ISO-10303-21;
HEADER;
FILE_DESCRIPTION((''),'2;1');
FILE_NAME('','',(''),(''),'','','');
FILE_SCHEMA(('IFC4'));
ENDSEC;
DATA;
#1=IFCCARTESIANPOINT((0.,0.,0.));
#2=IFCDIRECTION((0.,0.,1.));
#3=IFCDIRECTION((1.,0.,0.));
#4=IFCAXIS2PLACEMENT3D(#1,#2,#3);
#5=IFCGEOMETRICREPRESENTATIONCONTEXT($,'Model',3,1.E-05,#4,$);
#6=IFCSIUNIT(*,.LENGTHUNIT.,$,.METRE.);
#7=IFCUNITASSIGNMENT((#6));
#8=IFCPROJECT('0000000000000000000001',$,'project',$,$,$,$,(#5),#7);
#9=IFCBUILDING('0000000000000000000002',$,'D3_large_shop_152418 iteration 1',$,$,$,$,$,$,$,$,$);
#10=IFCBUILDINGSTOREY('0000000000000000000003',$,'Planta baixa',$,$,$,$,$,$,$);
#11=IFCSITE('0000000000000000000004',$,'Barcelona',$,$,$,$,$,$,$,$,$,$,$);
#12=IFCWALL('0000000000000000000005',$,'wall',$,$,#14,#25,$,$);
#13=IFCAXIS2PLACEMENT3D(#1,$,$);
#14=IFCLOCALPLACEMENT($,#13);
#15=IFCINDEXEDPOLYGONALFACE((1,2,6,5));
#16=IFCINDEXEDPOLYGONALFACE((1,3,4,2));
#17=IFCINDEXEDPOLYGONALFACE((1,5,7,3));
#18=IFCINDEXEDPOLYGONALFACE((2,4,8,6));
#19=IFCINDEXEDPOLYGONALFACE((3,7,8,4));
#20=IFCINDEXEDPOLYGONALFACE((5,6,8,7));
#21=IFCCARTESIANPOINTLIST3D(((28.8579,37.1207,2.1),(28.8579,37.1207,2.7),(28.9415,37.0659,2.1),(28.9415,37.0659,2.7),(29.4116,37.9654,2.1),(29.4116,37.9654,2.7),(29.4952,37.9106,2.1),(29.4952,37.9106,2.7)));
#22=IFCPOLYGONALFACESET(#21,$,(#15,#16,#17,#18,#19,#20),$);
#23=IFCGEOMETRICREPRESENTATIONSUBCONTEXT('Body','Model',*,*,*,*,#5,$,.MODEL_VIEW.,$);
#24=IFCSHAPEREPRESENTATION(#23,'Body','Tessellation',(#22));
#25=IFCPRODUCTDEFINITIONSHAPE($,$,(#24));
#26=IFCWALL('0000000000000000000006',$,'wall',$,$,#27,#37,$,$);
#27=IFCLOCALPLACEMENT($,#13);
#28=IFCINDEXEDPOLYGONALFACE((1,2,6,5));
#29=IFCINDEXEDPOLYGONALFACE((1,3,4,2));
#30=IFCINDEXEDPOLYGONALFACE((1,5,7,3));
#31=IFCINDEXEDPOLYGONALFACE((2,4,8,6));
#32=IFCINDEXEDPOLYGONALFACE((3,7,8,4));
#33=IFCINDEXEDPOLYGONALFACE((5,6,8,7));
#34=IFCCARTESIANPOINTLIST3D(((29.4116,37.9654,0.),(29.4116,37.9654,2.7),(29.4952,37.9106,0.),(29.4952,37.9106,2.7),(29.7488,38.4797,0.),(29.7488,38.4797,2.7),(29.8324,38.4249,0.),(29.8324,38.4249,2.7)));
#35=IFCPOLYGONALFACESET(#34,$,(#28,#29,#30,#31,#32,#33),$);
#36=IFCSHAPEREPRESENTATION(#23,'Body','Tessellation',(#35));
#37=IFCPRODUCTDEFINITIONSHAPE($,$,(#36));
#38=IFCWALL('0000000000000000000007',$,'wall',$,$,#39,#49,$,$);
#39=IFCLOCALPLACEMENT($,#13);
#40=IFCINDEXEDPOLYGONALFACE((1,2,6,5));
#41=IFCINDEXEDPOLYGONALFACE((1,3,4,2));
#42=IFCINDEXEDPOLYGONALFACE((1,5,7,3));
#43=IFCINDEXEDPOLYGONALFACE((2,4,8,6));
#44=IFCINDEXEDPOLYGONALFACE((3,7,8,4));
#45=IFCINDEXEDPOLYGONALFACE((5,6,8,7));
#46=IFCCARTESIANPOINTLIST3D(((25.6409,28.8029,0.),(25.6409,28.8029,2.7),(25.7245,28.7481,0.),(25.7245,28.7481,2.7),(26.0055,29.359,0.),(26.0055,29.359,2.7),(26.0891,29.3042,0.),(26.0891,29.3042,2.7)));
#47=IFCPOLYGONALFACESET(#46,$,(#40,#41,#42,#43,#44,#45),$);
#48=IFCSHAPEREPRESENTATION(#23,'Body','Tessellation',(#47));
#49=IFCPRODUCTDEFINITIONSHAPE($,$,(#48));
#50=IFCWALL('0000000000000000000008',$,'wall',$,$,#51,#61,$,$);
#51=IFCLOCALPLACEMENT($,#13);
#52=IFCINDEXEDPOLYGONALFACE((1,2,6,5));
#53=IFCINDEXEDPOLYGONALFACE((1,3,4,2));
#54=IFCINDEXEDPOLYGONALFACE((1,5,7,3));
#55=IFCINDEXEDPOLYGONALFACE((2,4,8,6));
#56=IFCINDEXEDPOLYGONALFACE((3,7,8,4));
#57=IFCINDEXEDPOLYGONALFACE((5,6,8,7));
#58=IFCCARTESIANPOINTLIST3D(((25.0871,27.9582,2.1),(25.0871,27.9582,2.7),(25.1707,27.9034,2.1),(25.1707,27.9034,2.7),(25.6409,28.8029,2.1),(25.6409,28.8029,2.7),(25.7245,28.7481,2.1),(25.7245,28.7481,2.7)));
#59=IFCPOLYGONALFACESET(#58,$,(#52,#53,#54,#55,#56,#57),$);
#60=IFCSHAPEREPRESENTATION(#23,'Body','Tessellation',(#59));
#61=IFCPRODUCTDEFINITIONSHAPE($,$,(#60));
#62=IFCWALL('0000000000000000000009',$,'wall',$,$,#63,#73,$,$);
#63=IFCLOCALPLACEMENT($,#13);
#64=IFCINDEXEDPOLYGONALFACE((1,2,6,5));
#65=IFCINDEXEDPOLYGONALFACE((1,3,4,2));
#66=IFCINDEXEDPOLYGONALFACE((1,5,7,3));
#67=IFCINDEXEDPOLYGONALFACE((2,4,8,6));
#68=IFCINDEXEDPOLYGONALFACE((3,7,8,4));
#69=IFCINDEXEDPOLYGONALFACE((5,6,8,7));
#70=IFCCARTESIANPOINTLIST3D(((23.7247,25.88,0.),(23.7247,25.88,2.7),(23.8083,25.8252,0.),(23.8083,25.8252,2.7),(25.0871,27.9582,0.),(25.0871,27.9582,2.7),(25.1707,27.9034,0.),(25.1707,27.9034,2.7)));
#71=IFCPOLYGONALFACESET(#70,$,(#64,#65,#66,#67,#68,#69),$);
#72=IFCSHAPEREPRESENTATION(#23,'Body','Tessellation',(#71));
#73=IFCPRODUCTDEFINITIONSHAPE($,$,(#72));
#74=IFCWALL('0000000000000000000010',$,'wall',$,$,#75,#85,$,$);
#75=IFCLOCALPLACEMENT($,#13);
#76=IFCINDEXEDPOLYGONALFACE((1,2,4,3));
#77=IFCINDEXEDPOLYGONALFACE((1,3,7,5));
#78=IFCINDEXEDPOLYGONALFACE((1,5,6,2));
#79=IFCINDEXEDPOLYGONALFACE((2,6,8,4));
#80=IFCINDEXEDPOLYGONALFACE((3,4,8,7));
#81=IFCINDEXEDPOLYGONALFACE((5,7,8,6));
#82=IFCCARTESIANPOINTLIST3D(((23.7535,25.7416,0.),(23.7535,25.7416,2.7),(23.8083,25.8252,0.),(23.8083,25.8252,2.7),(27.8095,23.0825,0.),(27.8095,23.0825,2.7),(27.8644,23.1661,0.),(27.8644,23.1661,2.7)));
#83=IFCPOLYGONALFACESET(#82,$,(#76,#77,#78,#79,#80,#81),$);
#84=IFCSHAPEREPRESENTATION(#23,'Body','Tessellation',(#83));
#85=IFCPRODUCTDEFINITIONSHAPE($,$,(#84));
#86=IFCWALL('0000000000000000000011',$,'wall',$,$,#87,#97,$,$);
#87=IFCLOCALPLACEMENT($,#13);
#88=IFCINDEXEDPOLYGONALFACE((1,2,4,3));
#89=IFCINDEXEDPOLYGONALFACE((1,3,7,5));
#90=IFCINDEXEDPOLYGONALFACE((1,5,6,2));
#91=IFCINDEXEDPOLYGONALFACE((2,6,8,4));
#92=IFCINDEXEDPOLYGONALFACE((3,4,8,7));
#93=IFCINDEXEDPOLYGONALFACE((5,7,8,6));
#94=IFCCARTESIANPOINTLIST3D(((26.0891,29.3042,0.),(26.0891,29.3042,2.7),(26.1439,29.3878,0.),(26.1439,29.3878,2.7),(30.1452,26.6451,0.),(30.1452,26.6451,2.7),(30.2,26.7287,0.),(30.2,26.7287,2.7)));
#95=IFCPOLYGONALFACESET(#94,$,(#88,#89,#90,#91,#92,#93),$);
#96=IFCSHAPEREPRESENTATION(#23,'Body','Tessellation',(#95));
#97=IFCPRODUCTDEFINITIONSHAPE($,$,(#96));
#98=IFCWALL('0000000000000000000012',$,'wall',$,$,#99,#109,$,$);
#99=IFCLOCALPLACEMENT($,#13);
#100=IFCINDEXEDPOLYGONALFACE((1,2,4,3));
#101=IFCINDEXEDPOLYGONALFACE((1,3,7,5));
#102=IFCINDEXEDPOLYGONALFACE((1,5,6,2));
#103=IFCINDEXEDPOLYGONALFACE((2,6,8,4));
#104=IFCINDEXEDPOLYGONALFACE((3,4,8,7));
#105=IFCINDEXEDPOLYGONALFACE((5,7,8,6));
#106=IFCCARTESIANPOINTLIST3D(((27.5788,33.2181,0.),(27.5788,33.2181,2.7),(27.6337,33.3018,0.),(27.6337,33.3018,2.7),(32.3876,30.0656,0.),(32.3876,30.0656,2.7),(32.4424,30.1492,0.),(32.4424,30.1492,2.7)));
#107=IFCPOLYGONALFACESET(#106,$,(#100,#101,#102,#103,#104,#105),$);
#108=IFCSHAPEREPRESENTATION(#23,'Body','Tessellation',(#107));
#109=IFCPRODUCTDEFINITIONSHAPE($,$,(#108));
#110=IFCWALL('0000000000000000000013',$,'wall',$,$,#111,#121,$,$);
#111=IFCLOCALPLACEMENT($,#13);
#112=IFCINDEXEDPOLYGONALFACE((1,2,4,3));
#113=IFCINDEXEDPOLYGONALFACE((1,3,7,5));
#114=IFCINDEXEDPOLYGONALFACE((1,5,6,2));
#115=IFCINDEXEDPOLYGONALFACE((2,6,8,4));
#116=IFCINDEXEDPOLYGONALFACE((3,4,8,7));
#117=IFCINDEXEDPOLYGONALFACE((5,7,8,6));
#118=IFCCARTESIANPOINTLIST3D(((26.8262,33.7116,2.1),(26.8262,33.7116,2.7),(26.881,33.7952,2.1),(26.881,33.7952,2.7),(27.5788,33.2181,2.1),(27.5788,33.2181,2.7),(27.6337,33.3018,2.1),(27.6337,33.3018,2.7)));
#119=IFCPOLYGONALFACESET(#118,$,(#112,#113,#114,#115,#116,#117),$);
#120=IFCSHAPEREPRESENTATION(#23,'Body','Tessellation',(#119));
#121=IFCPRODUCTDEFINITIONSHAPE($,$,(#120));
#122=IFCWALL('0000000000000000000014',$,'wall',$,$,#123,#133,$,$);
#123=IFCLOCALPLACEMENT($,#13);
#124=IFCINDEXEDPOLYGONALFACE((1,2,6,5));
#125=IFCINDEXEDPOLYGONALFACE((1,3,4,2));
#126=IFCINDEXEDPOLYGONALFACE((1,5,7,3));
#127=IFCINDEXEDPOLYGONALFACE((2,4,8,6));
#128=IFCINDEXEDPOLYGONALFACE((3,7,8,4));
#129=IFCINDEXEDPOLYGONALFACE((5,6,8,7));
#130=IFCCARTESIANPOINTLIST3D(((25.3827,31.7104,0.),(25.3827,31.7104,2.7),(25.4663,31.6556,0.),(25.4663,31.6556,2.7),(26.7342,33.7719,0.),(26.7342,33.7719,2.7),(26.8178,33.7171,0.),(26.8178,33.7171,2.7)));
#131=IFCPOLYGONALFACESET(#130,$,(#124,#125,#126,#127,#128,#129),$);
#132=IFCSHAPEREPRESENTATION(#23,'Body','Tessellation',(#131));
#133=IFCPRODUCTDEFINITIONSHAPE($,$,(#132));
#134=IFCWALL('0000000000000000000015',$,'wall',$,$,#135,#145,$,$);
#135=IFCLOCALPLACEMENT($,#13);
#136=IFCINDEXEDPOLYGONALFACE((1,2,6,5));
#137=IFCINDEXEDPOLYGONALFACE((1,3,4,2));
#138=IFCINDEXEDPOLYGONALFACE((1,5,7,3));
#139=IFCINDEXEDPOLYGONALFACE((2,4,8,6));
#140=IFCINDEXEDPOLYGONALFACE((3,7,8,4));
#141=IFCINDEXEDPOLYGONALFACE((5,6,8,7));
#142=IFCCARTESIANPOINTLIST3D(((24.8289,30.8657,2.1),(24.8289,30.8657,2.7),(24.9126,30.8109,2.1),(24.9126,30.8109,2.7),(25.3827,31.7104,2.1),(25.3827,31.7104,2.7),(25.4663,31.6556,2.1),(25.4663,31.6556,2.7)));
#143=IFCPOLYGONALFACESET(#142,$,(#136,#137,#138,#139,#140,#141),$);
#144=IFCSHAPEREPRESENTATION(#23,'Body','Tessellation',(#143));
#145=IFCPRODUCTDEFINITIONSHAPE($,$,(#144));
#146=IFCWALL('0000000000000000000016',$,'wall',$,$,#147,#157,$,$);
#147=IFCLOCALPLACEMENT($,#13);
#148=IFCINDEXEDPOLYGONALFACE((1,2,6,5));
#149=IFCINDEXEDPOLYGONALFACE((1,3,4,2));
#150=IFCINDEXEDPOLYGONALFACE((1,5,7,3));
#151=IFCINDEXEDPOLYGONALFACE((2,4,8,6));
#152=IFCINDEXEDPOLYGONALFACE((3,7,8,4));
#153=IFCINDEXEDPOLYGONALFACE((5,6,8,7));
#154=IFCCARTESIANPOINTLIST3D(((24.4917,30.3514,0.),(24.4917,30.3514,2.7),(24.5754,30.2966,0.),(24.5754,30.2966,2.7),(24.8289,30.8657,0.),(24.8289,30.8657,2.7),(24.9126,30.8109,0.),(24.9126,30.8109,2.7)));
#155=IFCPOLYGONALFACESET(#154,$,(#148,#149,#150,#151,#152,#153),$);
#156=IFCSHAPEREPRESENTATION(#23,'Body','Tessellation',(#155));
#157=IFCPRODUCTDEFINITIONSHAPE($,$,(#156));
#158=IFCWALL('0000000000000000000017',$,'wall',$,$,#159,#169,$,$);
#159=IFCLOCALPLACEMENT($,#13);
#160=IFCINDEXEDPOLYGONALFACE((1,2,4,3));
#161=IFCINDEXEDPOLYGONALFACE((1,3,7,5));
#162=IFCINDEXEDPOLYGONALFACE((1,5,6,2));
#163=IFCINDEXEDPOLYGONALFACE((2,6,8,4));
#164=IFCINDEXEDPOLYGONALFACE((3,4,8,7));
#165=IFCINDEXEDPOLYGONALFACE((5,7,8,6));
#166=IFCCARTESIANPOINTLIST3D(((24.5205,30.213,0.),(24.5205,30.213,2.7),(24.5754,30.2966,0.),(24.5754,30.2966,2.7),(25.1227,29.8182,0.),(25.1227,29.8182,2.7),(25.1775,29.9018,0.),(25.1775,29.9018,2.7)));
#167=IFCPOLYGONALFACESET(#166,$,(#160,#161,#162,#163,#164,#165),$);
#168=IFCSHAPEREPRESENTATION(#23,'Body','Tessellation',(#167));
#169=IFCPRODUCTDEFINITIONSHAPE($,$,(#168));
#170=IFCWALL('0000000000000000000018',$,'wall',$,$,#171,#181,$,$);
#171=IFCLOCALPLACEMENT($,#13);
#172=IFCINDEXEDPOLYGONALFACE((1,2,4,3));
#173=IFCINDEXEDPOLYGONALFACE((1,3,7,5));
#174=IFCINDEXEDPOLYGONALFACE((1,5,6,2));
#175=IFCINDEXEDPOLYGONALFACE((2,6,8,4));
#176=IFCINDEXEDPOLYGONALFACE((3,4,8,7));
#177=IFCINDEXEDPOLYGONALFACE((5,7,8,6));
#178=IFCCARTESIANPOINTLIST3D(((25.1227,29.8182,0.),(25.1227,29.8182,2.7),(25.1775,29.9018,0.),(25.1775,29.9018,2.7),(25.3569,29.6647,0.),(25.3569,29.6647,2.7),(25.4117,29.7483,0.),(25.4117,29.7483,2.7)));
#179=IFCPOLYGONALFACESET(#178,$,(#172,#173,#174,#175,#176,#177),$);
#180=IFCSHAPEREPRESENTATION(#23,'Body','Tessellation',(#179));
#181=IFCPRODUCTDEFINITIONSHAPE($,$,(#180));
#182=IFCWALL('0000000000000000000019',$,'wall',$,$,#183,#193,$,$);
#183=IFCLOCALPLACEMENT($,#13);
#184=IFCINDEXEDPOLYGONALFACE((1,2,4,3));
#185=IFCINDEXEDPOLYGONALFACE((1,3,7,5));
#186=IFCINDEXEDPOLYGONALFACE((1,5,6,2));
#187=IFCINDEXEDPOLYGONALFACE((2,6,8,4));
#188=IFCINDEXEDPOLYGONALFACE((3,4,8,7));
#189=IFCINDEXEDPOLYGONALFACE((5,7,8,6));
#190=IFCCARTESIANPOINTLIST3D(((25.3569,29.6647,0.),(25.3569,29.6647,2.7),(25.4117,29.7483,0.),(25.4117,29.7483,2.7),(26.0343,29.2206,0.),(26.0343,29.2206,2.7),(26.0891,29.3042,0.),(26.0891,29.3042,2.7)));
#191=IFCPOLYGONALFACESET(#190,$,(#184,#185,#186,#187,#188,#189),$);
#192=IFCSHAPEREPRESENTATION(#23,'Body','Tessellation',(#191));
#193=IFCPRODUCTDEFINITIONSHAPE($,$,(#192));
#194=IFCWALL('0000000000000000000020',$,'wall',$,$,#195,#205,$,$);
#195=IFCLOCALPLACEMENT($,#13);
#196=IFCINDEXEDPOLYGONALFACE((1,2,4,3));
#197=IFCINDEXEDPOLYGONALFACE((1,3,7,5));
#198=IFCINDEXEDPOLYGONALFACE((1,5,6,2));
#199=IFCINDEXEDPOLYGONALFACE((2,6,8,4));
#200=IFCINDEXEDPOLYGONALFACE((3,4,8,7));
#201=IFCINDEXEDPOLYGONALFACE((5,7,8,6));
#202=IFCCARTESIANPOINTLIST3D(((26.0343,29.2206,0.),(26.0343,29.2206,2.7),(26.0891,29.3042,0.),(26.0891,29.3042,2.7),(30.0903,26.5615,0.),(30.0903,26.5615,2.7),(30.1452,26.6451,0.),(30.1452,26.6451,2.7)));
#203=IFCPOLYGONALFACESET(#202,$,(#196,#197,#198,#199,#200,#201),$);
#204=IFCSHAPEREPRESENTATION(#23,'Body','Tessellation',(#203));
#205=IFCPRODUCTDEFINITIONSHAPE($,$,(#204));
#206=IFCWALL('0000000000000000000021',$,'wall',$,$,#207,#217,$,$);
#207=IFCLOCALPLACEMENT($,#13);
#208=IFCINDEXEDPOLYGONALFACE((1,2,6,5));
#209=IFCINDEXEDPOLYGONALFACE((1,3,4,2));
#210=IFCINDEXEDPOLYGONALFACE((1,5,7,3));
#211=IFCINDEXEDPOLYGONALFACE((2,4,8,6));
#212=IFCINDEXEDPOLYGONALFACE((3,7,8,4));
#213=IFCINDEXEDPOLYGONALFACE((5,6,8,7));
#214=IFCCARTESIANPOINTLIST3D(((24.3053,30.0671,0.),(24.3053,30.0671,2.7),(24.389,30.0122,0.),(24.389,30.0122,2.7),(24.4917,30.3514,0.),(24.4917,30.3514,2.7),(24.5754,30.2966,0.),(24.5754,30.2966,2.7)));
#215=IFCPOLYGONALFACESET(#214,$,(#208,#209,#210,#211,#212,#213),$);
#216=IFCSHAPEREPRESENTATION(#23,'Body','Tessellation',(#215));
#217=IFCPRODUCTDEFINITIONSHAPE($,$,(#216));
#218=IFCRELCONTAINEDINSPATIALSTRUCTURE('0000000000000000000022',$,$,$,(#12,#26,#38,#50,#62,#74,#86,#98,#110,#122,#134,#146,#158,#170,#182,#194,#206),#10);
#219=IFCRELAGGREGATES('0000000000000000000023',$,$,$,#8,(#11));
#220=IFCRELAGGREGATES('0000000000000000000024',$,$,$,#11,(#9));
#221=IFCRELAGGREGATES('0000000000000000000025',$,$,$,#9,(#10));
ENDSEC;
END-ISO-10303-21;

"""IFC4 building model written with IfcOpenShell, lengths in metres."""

from ifc_helpers import new_model, si_unit, frame, origin, origin_with_axes, place, context, subcontext, project, spatial, polyline, outline, extrude, element, save


model = new_model("IFC4")

# Units and contexts
model_context = context("Model", 3, precision=1e-05, world=origin_with_axes())
body_context = subcontext(model_context, "Body", "Model", "MODEL_VIEW")
ifc_project = project(units=[si_unit("LENGTHUNIT", "METRE")], contexts=[model_context])

# Site, building, storey
site = spatial("IfcSite", under=ifc_project, Name="Barcelona")
building = spatial("IfcBuilding", under=site, Name="D3_large_shop_152418 iteration 1")
storey = spatial("IfcBuildingStorey", under=building, Name="Planta baixa")

# Walls
wall_1_placement = place(None, origin_with_axes())
element("IfcWall", 1, at=wall_1_placement, inside=storey, Name="wall", context=body_context, shape_type="SweptSolid", body=[
    extrude(outline(polyline([(28.8579, 37.1207), (29.4116, 37.9654), (29.4952, 37.9106), (28.9415, 37.0659), (28.8579, 37.1207)])), frame((0.0, 0.0, 2.1)), (0.0, 0.0, 1.0), 0.6),
])
wall_2_placement = place(None, origin_with_axes())
element("IfcWall", 2, at=wall_2_placement, inside=storey, Name="wall", context=body_context, shape_type="SweptSolid", body=[
    extrude(outline(polyline([(29.4116, 37.9654), (29.7488, 38.4797), (29.8324, 38.4249), (29.4952, 37.9106), (29.4116, 37.9654)])), origin(), (0.0, 0.0, 1.0), 2.7),
])
wall_3_placement = place(None, origin_with_axes())
element("IfcWall", 3, at=wall_3_placement, inside=storey, Name="wall", context=body_context, shape_type="SweptSolid", body=[
    extrude(outline(polyline([(26.0891, 29.3042), (25.7245, 28.7481), (25.6409, 28.8029), (26.0055, 29.359), (26.0891, 29.3042)])), origin(), (0.0, 0.0, 1.0), 2.7),
])
wall_4_placement = place(None, origin_with_axes())
element("IfcWall", 4, at=wall_4_placement, inside=storey, Name="wall", context=body_context, shape_type="SweptSolid", body=[
    extrude(outline(polyline([(25.7245, 28.7481), (25.1707, 27.9034), (25.0871, 27.9582), (25.6409, 28.8029), (25.7245, 28.7481)])), frame((0.0, 0.0, 2.1)), (0.0, 0.0, 1.0), 0.6),
])
wall_5_placement = place(None, origin_with_axes())
element("IfcWall", 5, at=wall_5_placement, inside=storey, Name="wall", context=body_context, shape_type="SweptSolid", body=[
    extrude(outline(polyline([(25.1707, 27.9034), (23.8083, 25.8252), (23.7247, 25.88), (25.0871, 27.9582), (25.1707, 27.9034)])), origin(), (0.0, 0.0, 1.0), 2.7),
])
wall_6_placement = place(None, origin_with_axes())
element("IfcWall", 6, at=wall_6_placement, inside=storey, Name="wall", context=body_context, shape_type="SweptSolid", body=[
    extrude(outline(polyline([(23.8083, 25.8252), (27.8644, 23.1661), (27.8095, 23.0825), (23.7535, 25.7416), (23.8083, 25.8252)])), origin(), (0.0, 0.0, 1.0), 2.7),
])
wall_7_placement = place(None, origin_with_axes())
element("IfcWall", 7, at=wall_7_placement, inside=storey, Name="wall", context=body_context, shape_type="SweptSolid", body=[
    extrude(outline(polyline([(30.1452, 26.6451), (26.0891, 29.3042), (26.1439, 29.3878), (30.2, 26.7287), (30.1452, 26.6451)])), origin(), (0.0, 0.0, 1.0), 2.7),
])
wall_8_placement = place(None, origin_with_axes())
element("IfcWall", 8, at=wall_8_placement, inside=storey, Name="wall", context=body_context, shape_type="SweptSolid", body=[
    extrude(outline(polyline([(32.3876, 30.0656), (27.5788, 33.2181), (27.6337, 33.3018), (32.4424, 30.1492), (32.3876, 30.0656)])), origin(), (0.0, 0.0, 1.0), 2.7),
])
wall_9_placement = place(None, origin_with_axes())
element("IfcWall", 9, at=wall_9_placement, inside=storey, Name="wall", context=body_context, shape_type="SweptSolid", body=[
    extrude(outline(polyline([(27.5788, 33.2181), (26.8262, 33.7116), (26.881, 33.7952), (27.6337, 33.3018), (27.5788, 33.2181)])), frame((0.0, 0.0, 2.1)), (0.0, 0.0, 1.0), 0.6),
])
wall_10_placement = place(None, origin_with_axes())
element("IfcWall", 10, at=wall_10_placement, inside=storey, Name="wall", context=body_context, shape_type="SweptSolid", body=[
    extrude(outline(polyline([(26.8178, 33.7171), (25.4663, 31.6556), (25.3827, 31.7104), (26.7342, 33.7719), (26.8178, 33.7171)])), origin(), (0.0, 0.0, 1.0), 2.7),
])
wall_11_placement = place(None, origin_with_axes())
element("IfcWall", 11, at=wall_11_placement, inside=storey, Name="wall", context=body_context, shape_type="SweptSolid", body=[
    extrude(outline(polyline([(25.4663, 31.6556), (24.9126, 30.8109), (24.8289, 30.8657), (25.3827, 31.7104), (25.4663, 31.6556)])), frame((0.0, 0.0, 2.1)), (0.0, 0.0, 1.0), 0.6),
])
wall_12_placement = place(None, origin_with_axes())
element("IfcWall", 12, at=wall_12_placement, inside=storey, Name="wall", context=body_context, shape_type="SweptSolid", body=[
    extrude(outline(polyline([(24.9126, 30.8109), (24.5754, 30.2966), (24.4917, 30.3514), (24.8289, 30.8657), (24.9126, 30.8109)])), origin(), (0.0, 0.0, 1.0), 2.7),
])
wall_13_placement = place(None, origin_with_axes())
element("IfcWall", 13, at=wall_13_placement, inside=storey, Name="wall", context=body_context, shape_type="SweptSolid", body=[
    extrude(outline(polyline([(24.5754, 30.2966), (25.1775, 29.9018), (25.1227, 29.8182), (24.5205, 30.213), (24.5754, 30.2966)])), origin(), (0.0, 0.0, 1.0), 2.7),
])
wall_14_placement = place(None, origin_with_axes())
element("IfcWall", 14, at=wall_14_placement, inside=storey, Name="wall", context=body_context, shape_type="SweptSolid", body=[
    extrude(outline(polyline([(25.1775, 29.9018), (25.4117, 29.7483), (25.3569, 29.6647), (25.1227, 29.8182), (25.1775, 29.9018)])), origin(), (0.0, 0.0, 1.0), 2.7),
])
wall_15_placement = place(None, origin_with_axes())
element("IfcWall", 15, at=wall_15_placement, inside=storey, Name="wall", context=body_context, shape_type="SweptSolid", body=[
    extrude(outline(polyline([(25.4117, 29.7483), (26.0891, 29.3042), (26.0343, 29.2206), (25.3569, 29.6647), (25.4117, 29.7483)])), origin(), (0.0, 0.0, 1.0), 2.7),
])
wall_16_placement = place(None, origin_with_axes())
element("IfcWall", 16, at=wall_16_placement, inside=storey, Name="wall", context=body_context, shape_type="SweptSolid", body=[
    extrude(outline(polyline([(26.0891, 29.3042), (30.1452, 26.6451), (30.0903, 26.5615), (26.0343, 29.2206), (26.0891, 29.3042)])), origin(), (0.0, 0.0, 1.0), 2.7),
])
wall_17_placement = place(None, origin_with_axes())
element("IfcWall", 17, at=wall_17_placement, inside=storey, Name="wall", context=body_context, shape_type="SweptSolid", body=[
    extrude(outline(polyline([(24.5754, 30.2966), (24.389, 30.0122), (24.3053, 30.0671), (24.4917, 30.3514), (24.5754, 30.2966)])), origin(), (0.0, 0.0, 1.0), 2.7),
])

save(model, "model.ifc")
